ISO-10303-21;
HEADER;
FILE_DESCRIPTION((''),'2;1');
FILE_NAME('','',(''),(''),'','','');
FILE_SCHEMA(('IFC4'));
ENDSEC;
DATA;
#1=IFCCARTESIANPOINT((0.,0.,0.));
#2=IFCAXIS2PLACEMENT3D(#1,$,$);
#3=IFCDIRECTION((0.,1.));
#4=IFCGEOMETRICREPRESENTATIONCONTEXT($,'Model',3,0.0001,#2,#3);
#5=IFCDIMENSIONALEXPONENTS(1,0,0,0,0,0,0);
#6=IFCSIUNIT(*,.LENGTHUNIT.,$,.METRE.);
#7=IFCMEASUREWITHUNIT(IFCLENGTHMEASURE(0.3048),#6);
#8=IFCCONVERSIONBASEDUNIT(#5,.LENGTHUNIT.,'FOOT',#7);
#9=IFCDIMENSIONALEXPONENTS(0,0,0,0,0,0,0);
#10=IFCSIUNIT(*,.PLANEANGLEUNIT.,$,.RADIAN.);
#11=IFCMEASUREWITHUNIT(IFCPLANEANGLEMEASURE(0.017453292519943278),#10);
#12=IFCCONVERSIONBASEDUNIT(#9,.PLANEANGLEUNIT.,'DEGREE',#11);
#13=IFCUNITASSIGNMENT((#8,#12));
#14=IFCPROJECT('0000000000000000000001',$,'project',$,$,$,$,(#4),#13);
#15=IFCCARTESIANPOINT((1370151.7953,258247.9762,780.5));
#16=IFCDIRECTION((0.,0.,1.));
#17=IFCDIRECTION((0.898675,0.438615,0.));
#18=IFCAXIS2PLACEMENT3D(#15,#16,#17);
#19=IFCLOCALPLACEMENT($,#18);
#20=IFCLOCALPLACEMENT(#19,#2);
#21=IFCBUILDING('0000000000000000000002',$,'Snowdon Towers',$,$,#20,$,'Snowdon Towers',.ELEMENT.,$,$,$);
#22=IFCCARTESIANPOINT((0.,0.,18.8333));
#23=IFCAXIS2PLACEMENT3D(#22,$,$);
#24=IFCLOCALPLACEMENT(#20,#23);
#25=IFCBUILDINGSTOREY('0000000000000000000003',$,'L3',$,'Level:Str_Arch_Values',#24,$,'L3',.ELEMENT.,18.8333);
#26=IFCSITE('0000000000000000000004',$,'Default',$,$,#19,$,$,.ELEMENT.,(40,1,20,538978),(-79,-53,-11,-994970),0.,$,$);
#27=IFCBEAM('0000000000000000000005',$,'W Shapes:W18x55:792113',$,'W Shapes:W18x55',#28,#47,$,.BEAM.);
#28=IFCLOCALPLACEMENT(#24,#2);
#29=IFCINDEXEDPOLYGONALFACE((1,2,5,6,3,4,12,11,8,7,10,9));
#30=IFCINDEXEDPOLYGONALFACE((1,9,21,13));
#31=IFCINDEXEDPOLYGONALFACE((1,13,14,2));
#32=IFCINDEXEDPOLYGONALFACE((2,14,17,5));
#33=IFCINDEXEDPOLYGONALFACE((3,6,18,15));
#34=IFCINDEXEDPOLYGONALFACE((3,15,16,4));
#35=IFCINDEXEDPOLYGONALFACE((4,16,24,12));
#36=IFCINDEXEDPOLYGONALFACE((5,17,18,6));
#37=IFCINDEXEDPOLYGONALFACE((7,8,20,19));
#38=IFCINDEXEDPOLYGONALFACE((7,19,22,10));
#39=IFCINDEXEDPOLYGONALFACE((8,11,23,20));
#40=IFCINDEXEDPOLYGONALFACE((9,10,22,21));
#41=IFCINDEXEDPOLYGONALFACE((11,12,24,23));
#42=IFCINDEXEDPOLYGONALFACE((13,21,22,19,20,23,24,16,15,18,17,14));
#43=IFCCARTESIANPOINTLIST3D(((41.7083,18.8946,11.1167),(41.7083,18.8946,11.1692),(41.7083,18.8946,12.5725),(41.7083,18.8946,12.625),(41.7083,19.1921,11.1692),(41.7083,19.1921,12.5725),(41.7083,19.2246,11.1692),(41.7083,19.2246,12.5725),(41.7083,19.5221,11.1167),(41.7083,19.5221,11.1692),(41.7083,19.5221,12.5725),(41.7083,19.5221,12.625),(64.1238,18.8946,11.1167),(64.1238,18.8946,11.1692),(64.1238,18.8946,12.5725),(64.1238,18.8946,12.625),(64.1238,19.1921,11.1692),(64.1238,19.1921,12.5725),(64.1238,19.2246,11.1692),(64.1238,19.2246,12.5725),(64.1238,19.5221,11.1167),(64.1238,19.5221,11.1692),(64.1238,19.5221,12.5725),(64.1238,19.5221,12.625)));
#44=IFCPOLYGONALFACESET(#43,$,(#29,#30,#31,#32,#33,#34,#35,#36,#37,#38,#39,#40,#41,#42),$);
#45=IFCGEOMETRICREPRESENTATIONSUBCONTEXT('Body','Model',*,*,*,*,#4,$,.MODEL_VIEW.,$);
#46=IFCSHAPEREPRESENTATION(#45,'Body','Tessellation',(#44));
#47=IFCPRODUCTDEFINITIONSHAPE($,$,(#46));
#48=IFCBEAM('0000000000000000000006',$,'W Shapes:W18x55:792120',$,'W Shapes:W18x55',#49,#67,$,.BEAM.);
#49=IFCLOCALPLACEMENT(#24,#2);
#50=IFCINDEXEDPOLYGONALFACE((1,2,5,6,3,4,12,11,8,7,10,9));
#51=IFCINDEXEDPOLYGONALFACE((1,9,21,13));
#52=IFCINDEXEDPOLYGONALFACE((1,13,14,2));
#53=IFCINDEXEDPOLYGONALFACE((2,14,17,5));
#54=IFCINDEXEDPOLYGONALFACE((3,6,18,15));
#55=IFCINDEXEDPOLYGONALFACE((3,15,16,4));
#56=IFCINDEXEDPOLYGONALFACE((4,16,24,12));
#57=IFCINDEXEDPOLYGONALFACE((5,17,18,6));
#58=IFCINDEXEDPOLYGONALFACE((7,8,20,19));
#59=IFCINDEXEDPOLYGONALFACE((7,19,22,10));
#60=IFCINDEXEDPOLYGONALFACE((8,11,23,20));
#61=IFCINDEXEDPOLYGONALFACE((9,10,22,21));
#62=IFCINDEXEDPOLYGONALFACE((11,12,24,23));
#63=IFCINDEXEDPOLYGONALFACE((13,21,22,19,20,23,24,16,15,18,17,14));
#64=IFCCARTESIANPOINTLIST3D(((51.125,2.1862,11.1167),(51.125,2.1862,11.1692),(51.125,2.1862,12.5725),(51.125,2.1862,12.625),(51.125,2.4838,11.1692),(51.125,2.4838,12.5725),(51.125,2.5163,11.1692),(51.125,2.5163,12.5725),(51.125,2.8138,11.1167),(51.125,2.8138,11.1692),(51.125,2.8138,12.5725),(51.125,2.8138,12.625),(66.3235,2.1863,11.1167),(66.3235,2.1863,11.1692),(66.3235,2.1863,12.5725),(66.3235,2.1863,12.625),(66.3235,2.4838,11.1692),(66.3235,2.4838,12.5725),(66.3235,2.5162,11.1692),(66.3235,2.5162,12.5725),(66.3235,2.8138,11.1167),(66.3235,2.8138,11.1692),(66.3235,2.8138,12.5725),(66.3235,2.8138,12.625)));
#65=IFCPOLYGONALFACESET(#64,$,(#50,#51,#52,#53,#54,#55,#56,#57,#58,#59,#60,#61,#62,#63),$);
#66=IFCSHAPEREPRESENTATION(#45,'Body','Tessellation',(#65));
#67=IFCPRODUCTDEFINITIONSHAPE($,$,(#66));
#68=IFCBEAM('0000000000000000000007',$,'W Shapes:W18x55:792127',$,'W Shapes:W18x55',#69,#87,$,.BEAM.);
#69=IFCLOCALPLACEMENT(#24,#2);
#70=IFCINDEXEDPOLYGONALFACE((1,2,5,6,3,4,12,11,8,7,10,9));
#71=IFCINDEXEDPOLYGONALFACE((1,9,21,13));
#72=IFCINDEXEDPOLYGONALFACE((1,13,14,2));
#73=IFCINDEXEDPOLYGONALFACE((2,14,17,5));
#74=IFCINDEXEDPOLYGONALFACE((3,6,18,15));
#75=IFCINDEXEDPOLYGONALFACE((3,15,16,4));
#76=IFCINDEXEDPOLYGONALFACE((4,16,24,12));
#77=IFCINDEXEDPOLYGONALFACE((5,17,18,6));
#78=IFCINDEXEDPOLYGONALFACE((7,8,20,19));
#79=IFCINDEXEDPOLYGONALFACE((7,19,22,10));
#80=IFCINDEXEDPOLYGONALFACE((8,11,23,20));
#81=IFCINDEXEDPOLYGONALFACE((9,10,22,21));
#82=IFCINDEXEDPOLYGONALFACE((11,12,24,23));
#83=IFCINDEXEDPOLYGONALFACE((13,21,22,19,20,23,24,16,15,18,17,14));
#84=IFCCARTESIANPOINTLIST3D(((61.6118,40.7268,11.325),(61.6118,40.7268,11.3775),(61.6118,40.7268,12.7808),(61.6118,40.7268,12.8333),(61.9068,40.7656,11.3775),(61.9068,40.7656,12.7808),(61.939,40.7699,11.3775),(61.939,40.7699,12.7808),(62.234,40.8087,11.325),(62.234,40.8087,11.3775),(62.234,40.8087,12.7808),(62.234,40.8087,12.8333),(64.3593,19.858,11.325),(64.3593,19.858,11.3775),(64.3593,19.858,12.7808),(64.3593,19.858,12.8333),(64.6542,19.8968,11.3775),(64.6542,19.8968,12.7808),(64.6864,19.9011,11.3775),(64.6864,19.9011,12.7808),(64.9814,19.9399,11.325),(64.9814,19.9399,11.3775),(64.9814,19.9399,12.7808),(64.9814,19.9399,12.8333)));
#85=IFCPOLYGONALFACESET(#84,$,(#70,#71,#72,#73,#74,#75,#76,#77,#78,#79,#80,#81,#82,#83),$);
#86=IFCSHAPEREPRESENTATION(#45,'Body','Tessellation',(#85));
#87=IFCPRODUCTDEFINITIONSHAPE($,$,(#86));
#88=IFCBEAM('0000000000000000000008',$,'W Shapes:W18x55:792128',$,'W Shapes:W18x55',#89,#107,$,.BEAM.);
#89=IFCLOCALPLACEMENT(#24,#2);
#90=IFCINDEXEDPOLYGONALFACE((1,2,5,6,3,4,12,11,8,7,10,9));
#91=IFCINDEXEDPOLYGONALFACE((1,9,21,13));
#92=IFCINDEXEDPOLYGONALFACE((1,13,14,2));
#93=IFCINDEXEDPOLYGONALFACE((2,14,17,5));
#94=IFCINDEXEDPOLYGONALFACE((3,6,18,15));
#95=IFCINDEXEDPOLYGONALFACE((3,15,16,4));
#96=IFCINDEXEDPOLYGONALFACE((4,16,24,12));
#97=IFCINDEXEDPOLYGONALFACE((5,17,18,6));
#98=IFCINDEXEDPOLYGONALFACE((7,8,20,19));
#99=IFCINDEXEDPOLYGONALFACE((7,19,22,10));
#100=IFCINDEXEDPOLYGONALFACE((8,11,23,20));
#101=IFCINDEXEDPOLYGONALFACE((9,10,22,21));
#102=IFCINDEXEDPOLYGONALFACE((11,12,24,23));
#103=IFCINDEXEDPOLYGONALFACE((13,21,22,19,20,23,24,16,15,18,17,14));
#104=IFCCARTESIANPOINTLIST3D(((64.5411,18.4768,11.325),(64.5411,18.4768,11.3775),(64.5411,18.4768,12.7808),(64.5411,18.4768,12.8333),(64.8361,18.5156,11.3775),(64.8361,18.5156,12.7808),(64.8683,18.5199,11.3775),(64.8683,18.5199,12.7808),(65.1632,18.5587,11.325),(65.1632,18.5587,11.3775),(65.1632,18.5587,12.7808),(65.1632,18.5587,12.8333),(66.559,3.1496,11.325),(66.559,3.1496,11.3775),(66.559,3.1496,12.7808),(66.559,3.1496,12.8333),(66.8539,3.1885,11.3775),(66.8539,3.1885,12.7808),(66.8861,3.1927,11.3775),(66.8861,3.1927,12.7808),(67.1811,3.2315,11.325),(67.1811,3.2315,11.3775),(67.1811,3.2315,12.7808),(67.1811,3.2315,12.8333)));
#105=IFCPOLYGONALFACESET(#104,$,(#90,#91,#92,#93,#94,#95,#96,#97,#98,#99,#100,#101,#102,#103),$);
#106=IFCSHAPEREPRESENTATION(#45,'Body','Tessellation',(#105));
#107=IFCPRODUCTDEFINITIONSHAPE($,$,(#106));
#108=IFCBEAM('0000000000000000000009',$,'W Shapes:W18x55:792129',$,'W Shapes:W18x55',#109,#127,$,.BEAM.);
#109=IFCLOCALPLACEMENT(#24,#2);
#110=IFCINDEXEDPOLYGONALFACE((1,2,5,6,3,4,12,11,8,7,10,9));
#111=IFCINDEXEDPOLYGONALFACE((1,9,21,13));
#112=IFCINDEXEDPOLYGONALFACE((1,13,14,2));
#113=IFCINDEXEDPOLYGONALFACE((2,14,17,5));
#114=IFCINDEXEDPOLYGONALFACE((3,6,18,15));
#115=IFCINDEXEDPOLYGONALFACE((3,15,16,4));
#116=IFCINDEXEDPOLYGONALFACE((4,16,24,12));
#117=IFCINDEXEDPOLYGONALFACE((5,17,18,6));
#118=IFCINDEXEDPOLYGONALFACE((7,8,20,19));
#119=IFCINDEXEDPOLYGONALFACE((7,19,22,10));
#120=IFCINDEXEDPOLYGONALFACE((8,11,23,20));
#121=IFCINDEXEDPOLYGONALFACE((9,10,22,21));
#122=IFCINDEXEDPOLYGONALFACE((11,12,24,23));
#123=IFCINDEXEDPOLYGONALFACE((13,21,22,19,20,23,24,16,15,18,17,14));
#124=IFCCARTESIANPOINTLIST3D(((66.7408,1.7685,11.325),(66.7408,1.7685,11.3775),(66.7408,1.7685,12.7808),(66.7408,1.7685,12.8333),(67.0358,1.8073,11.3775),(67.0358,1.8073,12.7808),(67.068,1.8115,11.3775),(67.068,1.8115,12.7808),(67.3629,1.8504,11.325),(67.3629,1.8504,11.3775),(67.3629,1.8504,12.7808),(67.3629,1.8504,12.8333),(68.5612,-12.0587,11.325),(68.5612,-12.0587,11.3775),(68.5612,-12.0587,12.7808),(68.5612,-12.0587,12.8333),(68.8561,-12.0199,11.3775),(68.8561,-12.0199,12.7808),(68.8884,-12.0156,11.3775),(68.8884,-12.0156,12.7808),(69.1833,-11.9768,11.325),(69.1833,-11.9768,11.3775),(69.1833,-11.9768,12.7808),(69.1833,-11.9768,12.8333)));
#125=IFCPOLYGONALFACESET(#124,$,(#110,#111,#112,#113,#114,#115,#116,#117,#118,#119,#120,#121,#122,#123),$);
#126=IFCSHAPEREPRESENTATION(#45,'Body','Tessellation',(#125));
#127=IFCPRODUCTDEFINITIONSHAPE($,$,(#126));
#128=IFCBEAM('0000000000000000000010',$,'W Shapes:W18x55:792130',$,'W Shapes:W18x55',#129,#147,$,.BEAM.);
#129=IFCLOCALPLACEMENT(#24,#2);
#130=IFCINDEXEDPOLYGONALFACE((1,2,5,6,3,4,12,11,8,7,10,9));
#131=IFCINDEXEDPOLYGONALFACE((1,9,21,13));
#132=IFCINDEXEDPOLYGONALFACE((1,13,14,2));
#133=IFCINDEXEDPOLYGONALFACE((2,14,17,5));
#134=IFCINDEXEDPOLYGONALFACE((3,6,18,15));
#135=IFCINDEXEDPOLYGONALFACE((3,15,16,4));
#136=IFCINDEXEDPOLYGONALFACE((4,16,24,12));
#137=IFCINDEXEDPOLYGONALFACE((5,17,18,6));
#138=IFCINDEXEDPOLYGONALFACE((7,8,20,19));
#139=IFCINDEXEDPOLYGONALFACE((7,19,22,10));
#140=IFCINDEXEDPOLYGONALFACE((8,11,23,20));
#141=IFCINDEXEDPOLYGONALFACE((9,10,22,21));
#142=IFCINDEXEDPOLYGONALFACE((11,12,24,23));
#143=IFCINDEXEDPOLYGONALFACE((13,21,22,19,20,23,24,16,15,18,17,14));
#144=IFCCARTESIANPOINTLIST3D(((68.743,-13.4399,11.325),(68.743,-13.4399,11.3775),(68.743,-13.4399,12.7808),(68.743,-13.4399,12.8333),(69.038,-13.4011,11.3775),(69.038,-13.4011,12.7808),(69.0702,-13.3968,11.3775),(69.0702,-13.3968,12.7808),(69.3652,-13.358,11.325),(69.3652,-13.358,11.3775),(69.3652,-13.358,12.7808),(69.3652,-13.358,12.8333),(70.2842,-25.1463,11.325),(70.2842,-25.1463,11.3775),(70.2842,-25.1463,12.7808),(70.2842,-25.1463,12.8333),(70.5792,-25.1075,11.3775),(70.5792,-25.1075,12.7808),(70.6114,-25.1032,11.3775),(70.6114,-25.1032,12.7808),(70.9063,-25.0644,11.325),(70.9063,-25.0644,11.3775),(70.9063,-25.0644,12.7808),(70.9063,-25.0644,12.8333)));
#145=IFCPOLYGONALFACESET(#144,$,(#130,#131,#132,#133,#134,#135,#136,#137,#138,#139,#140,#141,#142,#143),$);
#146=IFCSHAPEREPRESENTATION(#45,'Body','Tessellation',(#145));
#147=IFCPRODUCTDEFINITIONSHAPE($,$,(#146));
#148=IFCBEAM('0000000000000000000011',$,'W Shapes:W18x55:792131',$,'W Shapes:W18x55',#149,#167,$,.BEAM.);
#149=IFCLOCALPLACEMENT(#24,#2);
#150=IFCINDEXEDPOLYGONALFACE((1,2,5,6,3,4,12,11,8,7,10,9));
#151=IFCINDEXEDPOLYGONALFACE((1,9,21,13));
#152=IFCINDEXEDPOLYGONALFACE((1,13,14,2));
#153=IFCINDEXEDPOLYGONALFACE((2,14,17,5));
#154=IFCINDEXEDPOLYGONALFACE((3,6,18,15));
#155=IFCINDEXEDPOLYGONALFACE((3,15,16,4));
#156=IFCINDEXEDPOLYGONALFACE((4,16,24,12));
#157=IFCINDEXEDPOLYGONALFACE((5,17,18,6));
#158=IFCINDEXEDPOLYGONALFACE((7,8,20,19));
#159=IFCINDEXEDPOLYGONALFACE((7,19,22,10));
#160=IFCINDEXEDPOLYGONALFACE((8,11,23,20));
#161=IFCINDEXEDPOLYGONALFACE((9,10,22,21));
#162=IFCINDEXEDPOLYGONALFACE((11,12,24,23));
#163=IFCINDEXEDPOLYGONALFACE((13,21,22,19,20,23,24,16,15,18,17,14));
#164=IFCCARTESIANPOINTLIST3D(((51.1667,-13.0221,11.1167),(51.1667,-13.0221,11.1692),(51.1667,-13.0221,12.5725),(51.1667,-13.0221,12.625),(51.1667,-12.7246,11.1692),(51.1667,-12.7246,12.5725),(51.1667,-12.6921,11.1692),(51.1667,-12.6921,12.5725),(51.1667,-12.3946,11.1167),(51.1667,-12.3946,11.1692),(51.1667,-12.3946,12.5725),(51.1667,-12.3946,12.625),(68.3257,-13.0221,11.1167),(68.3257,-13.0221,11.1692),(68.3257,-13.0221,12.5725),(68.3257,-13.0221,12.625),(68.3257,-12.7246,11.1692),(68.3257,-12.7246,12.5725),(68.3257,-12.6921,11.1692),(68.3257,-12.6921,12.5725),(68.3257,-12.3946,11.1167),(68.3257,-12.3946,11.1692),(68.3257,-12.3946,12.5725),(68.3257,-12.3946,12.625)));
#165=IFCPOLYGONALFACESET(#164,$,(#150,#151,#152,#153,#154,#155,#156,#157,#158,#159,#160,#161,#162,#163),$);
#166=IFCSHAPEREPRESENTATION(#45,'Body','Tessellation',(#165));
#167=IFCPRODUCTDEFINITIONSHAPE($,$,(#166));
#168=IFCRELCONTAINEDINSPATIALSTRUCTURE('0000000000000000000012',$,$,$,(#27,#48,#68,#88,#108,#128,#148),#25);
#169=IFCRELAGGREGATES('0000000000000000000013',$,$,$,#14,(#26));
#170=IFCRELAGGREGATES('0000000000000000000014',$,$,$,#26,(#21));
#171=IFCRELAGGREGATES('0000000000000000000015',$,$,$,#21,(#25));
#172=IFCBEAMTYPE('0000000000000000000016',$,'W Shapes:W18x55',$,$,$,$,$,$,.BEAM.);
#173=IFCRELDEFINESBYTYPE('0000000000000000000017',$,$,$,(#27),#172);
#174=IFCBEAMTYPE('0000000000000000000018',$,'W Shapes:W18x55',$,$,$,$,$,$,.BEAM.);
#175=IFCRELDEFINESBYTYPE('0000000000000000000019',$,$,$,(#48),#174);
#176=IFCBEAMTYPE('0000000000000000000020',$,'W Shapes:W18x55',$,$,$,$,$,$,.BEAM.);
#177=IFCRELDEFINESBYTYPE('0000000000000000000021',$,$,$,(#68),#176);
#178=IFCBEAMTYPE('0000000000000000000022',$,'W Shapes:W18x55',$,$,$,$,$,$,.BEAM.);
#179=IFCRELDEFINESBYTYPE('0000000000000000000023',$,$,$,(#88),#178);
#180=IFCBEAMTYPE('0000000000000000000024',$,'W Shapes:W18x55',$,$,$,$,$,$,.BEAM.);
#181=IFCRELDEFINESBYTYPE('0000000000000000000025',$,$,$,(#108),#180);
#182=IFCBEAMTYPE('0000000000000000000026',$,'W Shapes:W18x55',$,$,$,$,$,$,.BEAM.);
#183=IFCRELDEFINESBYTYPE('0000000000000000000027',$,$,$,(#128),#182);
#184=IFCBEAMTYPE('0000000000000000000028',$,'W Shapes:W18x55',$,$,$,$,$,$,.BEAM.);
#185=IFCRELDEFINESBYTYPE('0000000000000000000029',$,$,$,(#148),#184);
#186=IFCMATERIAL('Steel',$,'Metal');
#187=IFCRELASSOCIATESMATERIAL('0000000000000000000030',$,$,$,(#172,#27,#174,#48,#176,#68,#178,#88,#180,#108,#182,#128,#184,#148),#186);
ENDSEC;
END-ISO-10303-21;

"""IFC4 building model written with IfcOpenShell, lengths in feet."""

from ifc_helpers import new_model, entity, si_unit, converted_unit, direction, frame, origin, place, context, subcontext, project, spatial, indexed_curve, outline, extrude, source, transform, mapped, material, type_object, type_shapes, element, save


model = new_model("IFC4")

# Units and contexts
model_context = context("Model", 3, precision=0.0001, world=origin(), true_north=direction((0.0, 1.0)))
body_context = subcontext(model_context, "Body", "Model", "MODEL_VIEW")
ifc_project = project(units=[converted_unit("LENGTHUNIT", "FOOT", entity("IfcLengthMeasure", 0.3048), si_unit("LENGTHUNIT", "METRE"), dimensions=[1, 0, 0, 0, 0, 0, 0]), converted_unit("PLANEANGLEUNIT", "DEGREE", entity("IfcPlaneAngleMeasure", 0.017453292519943278), si_unit("PLANEANGLEUNIT", "RADIAN"), dimensions=[0, 0, 0, 0, 0, 0, 0])], contexts=[model_context])

# Site, building, storey
site_placement = place(None, frame((1370151.7953, 258247.9762, 780.5), z_axis=(0.0, 0.0, 1.0), x_axis=(0.898675, 0.438615, 0.0)))
site = spatial("IfcSite", under=ifc_project, at=site_placement, Name="Default", CompositionType="ELEMENT", RefLatitude=(40, 1, 20, 538978), RefLongitude=(-79, -53, -11, -994970), RefElevation=0.0)
building_placement = place(site_placement, origin())
building = spatial("IfcBuilding", under=site, at=building_placement, Name="Snowdon Towers", LongName="Snowdon Towers", CompositionType="ELEMENT")
storey_placement = place(building_placement, frame((0.0, 0.0, 18.8333)))
storey = spatial("IfcBuildingStorey", under=building, at=storey_placement, Name="L3", ObjectType="Level:Str_Arch_Values", LongName="L3", CompositionType="ELEMENT", Elevation=18.8333)

# Shared definitions
ifc_material = material(Name="Steel", Category="Metal")

# Beams
beam_type_1 = type_object("IfcBeamType", Name="W Shapes:W18x55", PredefinedType="BEAM", material=ifc_material)
shared_shape_1 = source(origin(), body_context, "Body", "SweptSolid", [
    extrude(outline(indexed_curve([(-0.3138, -0.7017), (-0.3138, -0.7542), (0.3138, -0.7542), (0.3138, -0.7017), (0.0162, -0.7017), (0.0162, 0.7017), (0.3138, 0.7017), (0.3138, 0.7542), (-0.3137, 0.7542), (-0.3137, 0.7017), (-0.0163, 0.7017), (-0.0163, -0.7017), (-0.3138, -0.7017)], self_intersect=False)), frame((-11.5915, 0.0, 0.0), z_axis=(-1.0, 0.0, 0.0), x_axis=(0.0, -1.0, 0.0)), (0.0, 0.0, -1.0), 22.4154),
])
type_shapes(beam_type_1, [shared_shape_1])
beam_1_placement = place(storey_placement, frame((53.2998, 19.2083, 11.8708)))
element("IfcBeam", 1, at=beam_1_placement, inside=storey, type_object=beam_type_1, material=ifc_material, Name="W Shapes:W18x55:792113", ObjectType="W Shapes:W18x55", PredefinedType="BEAM", context=body_context, shape_type="MappedRepresentation", body=[
    mapped(shared_shape_1, transform((0.0, 0.0, 0.0), scale=1.0)),
])
beam_type_2 = type_object("IfcBeamType", Name="W Shapes:W18x55", PredefinedType="BEAM", material=ifc_material)
shared_shape_2 = source(origin(), body_context, "Body", "SweptSolid", [
    extrude(outline(indexed_curve([(-0.3138, -0.7017), (-0.3138, -0.7542), (0.3138, -0.7542), (0.3138, -0.7017), (0.0162, -0.7017), (0.0162, 0.7017), (0.3138, 0.7017), (0.3138, 0.7542), (-0.3137, 0.7542), (-0.3137, 0.7017), (-0.0163, 0.7017), (-0.0163, -0.7017), (-0.3138, -0.7017)], self_intersect=False)), frame((-8.2122, 0.0, 0.0), z_axis=(-1.0, 0.0, 0.0), x_axis=(0.0, -1.0, 0.0)), (0.0, 0.0, -1.0), 15.1985),
])
type_shapes(beam_type_2, [shared_shape_2])
beam_2_placement = place(storey_placement, frame((59.3372, 2.5, 11.8708)))
element("IfcBeam", 2, at=beam_2_placement, inside=storey, type_object=beam_type_2, material=ifc_material, Name="W Shapes:W18x55:792120", ObjectType="W Shapes:W18x55", PredefinedType="BEAM", context=body_context, shape_type="MappedRepresentation", body=[
    mapped(shared_shape_2, transform((0.0, 0.0, 0.0), scale=1.0)),
])
beam_type_3 = type_object("IfcBeamType", Name="W Shapes:W18x55", PredefinedType="BEAM", material=ifc_material)
shared_shape_3 = source(origin(), body_context, "Body", "SweptSolid", [
    extrude(outline(indexed_curve([(-0.3138, -0.7017), (-0.3138, -0.7542), (0.3138, -0.7542), (0.3138, -0.7017), (0.0162, -0.7017), (0.0162, 0.7017), (0.3138, 0.7017), (0.3138, 0.7542), (-0.3137, 0.7542), (-0.3137, 0.7017), (-0.0163, 0.7017), (-0.0163, -0.7017), (-0.3138, -0.7017)], self_intersect=False)), frame((-10.5172, 0.0, 0.0), z_axis=(-1.0, 0.0, 0.0), x_axis=(0.0, -1.0, 0.0)), (0.0, 0.0, -1.0), 21.0489),
])
type_shapes(beam_type_3, [shared_shape_3])
beam_3_placement = place(storey_placement, frame((63.2957, 30.3405, 12.0792), z_axis=(0.0, 0.0, 1.0), x_axis=(0.130526, -0.991445, 0.0)))
element("IfcBeam", 3, at=beam_3_placement, inside=storey, type_object=beam_type_3, material=ifc_material, Name="W Shapes:W18x55:792127", ObjectType="W Shapes:W18x55", PredefinedType="BEAM", context=body_context, shape_type="MappedRepresentation", body=[
    mapped(shared_shape_3, transform((0.0, 0.0, 0.0), scale=1.0)),
])
beam_type_4 = type_object("IfcBeamType", Name="W Shapes:W18x55", PredefinedType="BEAM", material=ifc_material)
shared_shape_4 = source(origin(), body_context, "Body", "SweptSolid", [
    extrude(outline(indexed_curve([(-0.3138, -0.7017), (-0.3138, -0.7542), (0.3138, -0.7542), (0.3138, -0.7017), (0.0162, -0.7017), (0.0162, 0.7017), (0.3138, 0.7017), (0.3138, 0.7542), (-0.3137, 0.7542), (-0.3137, 0.7017), (-0.0163, 0.7017), (-0.0163, -0.7017), (-0.3138, -0.7017)], self_intersect=False)), frame((-7.8065, 0.0, 0.0), z_axis=(-1.0, 0.0, 0.0), x_axis=(0.0, -1.0, 0.0)), (0.0, 0.0, -1.0), 15.4594),
])
type_shapes(beam_type_4, [shared_shape_4])
beam_4_placement = place(storey_placement, frame((65.8711, 10.778, 12.0792), z_axis=(0.0, 0.0, 1.0), x_axis=(0.130526, -0.991445, 0.0)))
element("IfcBeam", 4, at=beam_4_placement, inside=storey, type_object=beam_type_4, material=ifc_material, Name="W Shapes:W18x55:792128", ObjectType="W Shapes:W18x55", PredefinedType="BEAM", context=body_context, shape_type="MappedRepresentation", body=[
    mapped(shared_shape_4, transform((0.0, 0.0, 0.0), scale=1.0)),
])
beam_type_5 = type_object("IfcBeamType", Name="W Shapes:W18x55", PredefinedType="BEAM", material=ifc_material)
shared_shape_5 = source(origin(), body_context, "Body", "SweptSolid", [
    extrude(outline(indexed_curve([(-0.3138, -0.7017), (-0.3138, -0.7542), (0.3138, -0.7542), (0.3138, -0.7017), (0.0162, -0.7017), (0.0162, 0.7017), (0.3138, 0.7017), (0.3138, 0.7542), (-0.3137, 0.7542), (-0.3137, 0.7017), (-0.0163, 0.7017), (-0.0163, -0.7017), (-0.3138, -0.7017)], self_intersect=False)), frame((-7.05, 0.0, 0.0), z_axis=(-1.0, 0.0, 0.0), x_axis=(0.0, -1.0, 0.0)), (0.0, 0.0, -1.0), 13.9465),
])
type_shapes(beam_type_5, [shared_shape_5])
beam_5_placement = place(storey_placement, frame((67.9721, -5.1803, 12.0792), z_axis=(0.0, 0.0, 1.0), x_axis=(0.130526, -0.991445, 0.0)))
element("IfcBeam", 5, at=beam_5_placement, inside=storey, type_object=beam_type_5, material=ifc_material, Name="W Shapes:W18x55:792129", ObjectType="W Shapes:W18x55", PredefinedType="BEAM", context=body_context, shape_type="MappedRepresentation", body=[
    mapped(shared_shape_5, transform((0.0, 0.0, 0.0), scale=1.0)),
])
beam_type_6 = type_object("IfcBeamType", Name="W Shapes:W18x55", PredefinedType="BEAM", material=ifc_material)
shared_shape_6 = source(origin(), body_context, "Body", "SweptSolid", [
    extrude(outline(indexed_curve([(-0.3138, -0.7017), (-0.3138, -0.7542), (0.3138, -0.7542), (0.3138, -0.7017), (0.0162, -0.7017), (0.0162, 0.7017), (0.3138, 0.7017), (0.3138, 0.7542), (-0.3137, 0.7542), (-0.3137, 0.7017), (-0.0163, 0.7017), (-0.0163, -0.7017), (-0.3138, -0.7017)], self_intersect=False)), frame((-5.9188, 0.0, 0.0), z_axis=(-1.0, 0.0, 0.0), x_axis=(0.0, -1.0, 0.0)), (0.0, 0.0, -1.0), 11.8075),
])
type_shapes(beam_type_6, [shared_shape_6])
beam_6_placement = place(storey_placement, frame((69.8266, -19.2671, 12.0792), z_axis=(0.0, 0.0, 1.0), x_axis=(0.130526, -0.991445, 0.0)))
element("IfcBeam", 6, at=beam_6_placement, inside=storey, type_object=beam_type_6, material=ifc_material, Name="W Shapes:W18x55:792130", ObjectType="W Shapes:W18x55", PredefinedType="BEAM", context=body_context, shape_type="MappedRepresentation", body=[
    mapped(shared_shape_6, transform((0.0, 0.0, 0.0), scale=1.0)),
])
beam_type_7 = type_object("IfcBeamType", Name="W Shapes:W18x55", PredefinedType="BEAM", material=ifc_material)
shared_shape_7 = source(origin(), body_context, "Body", "SweptSolid", [
    extrude(outline(indexed_curve([(-0.3138, -0.7017), (-0.3138, -0.7542), (0.3138, -0.7542), (0.3138, -0.7017), (0.0162, -0.7017), (0.0162, 0.7017), (0.3138, 0.7017), (0.3138, 0.7542), (-0.3137, 0.7542), (-0.3137, 0.7017), (-0.0163, 0.7017), (-0.0163, -0.7017), (-0.3138, -0.7017)], self_intersect=False)), frame((-8.9216, 0.0, 0.0), z_axis=(-1.0, 0.0, 0.0), x_axis=(0.0, -1.0, 0.0)), (0.0, 0.0, -1.0), 17.159),
])
type_shapes(beam_type_7, [shared_shape_7])
beam_7_placement = place(storey_placement, frame((60.0883, -12.7083, 11.8708)))
element("IfcBeam", 7, at=beam_7_placement, inside=storey, type_object=beam_type_7, material=ifc_material, Name="W Shapes:W18x55:792131", ObjectType="W Shapes:W18x55", PredefinedType="BEAM", context=body_context, shape_type="MappedRepresentation", body=[
    mapped(shared_shape_7, transform((0.0, 0.0, 0.0), scale=1.0)),
])

save(model, "model.ifc")
